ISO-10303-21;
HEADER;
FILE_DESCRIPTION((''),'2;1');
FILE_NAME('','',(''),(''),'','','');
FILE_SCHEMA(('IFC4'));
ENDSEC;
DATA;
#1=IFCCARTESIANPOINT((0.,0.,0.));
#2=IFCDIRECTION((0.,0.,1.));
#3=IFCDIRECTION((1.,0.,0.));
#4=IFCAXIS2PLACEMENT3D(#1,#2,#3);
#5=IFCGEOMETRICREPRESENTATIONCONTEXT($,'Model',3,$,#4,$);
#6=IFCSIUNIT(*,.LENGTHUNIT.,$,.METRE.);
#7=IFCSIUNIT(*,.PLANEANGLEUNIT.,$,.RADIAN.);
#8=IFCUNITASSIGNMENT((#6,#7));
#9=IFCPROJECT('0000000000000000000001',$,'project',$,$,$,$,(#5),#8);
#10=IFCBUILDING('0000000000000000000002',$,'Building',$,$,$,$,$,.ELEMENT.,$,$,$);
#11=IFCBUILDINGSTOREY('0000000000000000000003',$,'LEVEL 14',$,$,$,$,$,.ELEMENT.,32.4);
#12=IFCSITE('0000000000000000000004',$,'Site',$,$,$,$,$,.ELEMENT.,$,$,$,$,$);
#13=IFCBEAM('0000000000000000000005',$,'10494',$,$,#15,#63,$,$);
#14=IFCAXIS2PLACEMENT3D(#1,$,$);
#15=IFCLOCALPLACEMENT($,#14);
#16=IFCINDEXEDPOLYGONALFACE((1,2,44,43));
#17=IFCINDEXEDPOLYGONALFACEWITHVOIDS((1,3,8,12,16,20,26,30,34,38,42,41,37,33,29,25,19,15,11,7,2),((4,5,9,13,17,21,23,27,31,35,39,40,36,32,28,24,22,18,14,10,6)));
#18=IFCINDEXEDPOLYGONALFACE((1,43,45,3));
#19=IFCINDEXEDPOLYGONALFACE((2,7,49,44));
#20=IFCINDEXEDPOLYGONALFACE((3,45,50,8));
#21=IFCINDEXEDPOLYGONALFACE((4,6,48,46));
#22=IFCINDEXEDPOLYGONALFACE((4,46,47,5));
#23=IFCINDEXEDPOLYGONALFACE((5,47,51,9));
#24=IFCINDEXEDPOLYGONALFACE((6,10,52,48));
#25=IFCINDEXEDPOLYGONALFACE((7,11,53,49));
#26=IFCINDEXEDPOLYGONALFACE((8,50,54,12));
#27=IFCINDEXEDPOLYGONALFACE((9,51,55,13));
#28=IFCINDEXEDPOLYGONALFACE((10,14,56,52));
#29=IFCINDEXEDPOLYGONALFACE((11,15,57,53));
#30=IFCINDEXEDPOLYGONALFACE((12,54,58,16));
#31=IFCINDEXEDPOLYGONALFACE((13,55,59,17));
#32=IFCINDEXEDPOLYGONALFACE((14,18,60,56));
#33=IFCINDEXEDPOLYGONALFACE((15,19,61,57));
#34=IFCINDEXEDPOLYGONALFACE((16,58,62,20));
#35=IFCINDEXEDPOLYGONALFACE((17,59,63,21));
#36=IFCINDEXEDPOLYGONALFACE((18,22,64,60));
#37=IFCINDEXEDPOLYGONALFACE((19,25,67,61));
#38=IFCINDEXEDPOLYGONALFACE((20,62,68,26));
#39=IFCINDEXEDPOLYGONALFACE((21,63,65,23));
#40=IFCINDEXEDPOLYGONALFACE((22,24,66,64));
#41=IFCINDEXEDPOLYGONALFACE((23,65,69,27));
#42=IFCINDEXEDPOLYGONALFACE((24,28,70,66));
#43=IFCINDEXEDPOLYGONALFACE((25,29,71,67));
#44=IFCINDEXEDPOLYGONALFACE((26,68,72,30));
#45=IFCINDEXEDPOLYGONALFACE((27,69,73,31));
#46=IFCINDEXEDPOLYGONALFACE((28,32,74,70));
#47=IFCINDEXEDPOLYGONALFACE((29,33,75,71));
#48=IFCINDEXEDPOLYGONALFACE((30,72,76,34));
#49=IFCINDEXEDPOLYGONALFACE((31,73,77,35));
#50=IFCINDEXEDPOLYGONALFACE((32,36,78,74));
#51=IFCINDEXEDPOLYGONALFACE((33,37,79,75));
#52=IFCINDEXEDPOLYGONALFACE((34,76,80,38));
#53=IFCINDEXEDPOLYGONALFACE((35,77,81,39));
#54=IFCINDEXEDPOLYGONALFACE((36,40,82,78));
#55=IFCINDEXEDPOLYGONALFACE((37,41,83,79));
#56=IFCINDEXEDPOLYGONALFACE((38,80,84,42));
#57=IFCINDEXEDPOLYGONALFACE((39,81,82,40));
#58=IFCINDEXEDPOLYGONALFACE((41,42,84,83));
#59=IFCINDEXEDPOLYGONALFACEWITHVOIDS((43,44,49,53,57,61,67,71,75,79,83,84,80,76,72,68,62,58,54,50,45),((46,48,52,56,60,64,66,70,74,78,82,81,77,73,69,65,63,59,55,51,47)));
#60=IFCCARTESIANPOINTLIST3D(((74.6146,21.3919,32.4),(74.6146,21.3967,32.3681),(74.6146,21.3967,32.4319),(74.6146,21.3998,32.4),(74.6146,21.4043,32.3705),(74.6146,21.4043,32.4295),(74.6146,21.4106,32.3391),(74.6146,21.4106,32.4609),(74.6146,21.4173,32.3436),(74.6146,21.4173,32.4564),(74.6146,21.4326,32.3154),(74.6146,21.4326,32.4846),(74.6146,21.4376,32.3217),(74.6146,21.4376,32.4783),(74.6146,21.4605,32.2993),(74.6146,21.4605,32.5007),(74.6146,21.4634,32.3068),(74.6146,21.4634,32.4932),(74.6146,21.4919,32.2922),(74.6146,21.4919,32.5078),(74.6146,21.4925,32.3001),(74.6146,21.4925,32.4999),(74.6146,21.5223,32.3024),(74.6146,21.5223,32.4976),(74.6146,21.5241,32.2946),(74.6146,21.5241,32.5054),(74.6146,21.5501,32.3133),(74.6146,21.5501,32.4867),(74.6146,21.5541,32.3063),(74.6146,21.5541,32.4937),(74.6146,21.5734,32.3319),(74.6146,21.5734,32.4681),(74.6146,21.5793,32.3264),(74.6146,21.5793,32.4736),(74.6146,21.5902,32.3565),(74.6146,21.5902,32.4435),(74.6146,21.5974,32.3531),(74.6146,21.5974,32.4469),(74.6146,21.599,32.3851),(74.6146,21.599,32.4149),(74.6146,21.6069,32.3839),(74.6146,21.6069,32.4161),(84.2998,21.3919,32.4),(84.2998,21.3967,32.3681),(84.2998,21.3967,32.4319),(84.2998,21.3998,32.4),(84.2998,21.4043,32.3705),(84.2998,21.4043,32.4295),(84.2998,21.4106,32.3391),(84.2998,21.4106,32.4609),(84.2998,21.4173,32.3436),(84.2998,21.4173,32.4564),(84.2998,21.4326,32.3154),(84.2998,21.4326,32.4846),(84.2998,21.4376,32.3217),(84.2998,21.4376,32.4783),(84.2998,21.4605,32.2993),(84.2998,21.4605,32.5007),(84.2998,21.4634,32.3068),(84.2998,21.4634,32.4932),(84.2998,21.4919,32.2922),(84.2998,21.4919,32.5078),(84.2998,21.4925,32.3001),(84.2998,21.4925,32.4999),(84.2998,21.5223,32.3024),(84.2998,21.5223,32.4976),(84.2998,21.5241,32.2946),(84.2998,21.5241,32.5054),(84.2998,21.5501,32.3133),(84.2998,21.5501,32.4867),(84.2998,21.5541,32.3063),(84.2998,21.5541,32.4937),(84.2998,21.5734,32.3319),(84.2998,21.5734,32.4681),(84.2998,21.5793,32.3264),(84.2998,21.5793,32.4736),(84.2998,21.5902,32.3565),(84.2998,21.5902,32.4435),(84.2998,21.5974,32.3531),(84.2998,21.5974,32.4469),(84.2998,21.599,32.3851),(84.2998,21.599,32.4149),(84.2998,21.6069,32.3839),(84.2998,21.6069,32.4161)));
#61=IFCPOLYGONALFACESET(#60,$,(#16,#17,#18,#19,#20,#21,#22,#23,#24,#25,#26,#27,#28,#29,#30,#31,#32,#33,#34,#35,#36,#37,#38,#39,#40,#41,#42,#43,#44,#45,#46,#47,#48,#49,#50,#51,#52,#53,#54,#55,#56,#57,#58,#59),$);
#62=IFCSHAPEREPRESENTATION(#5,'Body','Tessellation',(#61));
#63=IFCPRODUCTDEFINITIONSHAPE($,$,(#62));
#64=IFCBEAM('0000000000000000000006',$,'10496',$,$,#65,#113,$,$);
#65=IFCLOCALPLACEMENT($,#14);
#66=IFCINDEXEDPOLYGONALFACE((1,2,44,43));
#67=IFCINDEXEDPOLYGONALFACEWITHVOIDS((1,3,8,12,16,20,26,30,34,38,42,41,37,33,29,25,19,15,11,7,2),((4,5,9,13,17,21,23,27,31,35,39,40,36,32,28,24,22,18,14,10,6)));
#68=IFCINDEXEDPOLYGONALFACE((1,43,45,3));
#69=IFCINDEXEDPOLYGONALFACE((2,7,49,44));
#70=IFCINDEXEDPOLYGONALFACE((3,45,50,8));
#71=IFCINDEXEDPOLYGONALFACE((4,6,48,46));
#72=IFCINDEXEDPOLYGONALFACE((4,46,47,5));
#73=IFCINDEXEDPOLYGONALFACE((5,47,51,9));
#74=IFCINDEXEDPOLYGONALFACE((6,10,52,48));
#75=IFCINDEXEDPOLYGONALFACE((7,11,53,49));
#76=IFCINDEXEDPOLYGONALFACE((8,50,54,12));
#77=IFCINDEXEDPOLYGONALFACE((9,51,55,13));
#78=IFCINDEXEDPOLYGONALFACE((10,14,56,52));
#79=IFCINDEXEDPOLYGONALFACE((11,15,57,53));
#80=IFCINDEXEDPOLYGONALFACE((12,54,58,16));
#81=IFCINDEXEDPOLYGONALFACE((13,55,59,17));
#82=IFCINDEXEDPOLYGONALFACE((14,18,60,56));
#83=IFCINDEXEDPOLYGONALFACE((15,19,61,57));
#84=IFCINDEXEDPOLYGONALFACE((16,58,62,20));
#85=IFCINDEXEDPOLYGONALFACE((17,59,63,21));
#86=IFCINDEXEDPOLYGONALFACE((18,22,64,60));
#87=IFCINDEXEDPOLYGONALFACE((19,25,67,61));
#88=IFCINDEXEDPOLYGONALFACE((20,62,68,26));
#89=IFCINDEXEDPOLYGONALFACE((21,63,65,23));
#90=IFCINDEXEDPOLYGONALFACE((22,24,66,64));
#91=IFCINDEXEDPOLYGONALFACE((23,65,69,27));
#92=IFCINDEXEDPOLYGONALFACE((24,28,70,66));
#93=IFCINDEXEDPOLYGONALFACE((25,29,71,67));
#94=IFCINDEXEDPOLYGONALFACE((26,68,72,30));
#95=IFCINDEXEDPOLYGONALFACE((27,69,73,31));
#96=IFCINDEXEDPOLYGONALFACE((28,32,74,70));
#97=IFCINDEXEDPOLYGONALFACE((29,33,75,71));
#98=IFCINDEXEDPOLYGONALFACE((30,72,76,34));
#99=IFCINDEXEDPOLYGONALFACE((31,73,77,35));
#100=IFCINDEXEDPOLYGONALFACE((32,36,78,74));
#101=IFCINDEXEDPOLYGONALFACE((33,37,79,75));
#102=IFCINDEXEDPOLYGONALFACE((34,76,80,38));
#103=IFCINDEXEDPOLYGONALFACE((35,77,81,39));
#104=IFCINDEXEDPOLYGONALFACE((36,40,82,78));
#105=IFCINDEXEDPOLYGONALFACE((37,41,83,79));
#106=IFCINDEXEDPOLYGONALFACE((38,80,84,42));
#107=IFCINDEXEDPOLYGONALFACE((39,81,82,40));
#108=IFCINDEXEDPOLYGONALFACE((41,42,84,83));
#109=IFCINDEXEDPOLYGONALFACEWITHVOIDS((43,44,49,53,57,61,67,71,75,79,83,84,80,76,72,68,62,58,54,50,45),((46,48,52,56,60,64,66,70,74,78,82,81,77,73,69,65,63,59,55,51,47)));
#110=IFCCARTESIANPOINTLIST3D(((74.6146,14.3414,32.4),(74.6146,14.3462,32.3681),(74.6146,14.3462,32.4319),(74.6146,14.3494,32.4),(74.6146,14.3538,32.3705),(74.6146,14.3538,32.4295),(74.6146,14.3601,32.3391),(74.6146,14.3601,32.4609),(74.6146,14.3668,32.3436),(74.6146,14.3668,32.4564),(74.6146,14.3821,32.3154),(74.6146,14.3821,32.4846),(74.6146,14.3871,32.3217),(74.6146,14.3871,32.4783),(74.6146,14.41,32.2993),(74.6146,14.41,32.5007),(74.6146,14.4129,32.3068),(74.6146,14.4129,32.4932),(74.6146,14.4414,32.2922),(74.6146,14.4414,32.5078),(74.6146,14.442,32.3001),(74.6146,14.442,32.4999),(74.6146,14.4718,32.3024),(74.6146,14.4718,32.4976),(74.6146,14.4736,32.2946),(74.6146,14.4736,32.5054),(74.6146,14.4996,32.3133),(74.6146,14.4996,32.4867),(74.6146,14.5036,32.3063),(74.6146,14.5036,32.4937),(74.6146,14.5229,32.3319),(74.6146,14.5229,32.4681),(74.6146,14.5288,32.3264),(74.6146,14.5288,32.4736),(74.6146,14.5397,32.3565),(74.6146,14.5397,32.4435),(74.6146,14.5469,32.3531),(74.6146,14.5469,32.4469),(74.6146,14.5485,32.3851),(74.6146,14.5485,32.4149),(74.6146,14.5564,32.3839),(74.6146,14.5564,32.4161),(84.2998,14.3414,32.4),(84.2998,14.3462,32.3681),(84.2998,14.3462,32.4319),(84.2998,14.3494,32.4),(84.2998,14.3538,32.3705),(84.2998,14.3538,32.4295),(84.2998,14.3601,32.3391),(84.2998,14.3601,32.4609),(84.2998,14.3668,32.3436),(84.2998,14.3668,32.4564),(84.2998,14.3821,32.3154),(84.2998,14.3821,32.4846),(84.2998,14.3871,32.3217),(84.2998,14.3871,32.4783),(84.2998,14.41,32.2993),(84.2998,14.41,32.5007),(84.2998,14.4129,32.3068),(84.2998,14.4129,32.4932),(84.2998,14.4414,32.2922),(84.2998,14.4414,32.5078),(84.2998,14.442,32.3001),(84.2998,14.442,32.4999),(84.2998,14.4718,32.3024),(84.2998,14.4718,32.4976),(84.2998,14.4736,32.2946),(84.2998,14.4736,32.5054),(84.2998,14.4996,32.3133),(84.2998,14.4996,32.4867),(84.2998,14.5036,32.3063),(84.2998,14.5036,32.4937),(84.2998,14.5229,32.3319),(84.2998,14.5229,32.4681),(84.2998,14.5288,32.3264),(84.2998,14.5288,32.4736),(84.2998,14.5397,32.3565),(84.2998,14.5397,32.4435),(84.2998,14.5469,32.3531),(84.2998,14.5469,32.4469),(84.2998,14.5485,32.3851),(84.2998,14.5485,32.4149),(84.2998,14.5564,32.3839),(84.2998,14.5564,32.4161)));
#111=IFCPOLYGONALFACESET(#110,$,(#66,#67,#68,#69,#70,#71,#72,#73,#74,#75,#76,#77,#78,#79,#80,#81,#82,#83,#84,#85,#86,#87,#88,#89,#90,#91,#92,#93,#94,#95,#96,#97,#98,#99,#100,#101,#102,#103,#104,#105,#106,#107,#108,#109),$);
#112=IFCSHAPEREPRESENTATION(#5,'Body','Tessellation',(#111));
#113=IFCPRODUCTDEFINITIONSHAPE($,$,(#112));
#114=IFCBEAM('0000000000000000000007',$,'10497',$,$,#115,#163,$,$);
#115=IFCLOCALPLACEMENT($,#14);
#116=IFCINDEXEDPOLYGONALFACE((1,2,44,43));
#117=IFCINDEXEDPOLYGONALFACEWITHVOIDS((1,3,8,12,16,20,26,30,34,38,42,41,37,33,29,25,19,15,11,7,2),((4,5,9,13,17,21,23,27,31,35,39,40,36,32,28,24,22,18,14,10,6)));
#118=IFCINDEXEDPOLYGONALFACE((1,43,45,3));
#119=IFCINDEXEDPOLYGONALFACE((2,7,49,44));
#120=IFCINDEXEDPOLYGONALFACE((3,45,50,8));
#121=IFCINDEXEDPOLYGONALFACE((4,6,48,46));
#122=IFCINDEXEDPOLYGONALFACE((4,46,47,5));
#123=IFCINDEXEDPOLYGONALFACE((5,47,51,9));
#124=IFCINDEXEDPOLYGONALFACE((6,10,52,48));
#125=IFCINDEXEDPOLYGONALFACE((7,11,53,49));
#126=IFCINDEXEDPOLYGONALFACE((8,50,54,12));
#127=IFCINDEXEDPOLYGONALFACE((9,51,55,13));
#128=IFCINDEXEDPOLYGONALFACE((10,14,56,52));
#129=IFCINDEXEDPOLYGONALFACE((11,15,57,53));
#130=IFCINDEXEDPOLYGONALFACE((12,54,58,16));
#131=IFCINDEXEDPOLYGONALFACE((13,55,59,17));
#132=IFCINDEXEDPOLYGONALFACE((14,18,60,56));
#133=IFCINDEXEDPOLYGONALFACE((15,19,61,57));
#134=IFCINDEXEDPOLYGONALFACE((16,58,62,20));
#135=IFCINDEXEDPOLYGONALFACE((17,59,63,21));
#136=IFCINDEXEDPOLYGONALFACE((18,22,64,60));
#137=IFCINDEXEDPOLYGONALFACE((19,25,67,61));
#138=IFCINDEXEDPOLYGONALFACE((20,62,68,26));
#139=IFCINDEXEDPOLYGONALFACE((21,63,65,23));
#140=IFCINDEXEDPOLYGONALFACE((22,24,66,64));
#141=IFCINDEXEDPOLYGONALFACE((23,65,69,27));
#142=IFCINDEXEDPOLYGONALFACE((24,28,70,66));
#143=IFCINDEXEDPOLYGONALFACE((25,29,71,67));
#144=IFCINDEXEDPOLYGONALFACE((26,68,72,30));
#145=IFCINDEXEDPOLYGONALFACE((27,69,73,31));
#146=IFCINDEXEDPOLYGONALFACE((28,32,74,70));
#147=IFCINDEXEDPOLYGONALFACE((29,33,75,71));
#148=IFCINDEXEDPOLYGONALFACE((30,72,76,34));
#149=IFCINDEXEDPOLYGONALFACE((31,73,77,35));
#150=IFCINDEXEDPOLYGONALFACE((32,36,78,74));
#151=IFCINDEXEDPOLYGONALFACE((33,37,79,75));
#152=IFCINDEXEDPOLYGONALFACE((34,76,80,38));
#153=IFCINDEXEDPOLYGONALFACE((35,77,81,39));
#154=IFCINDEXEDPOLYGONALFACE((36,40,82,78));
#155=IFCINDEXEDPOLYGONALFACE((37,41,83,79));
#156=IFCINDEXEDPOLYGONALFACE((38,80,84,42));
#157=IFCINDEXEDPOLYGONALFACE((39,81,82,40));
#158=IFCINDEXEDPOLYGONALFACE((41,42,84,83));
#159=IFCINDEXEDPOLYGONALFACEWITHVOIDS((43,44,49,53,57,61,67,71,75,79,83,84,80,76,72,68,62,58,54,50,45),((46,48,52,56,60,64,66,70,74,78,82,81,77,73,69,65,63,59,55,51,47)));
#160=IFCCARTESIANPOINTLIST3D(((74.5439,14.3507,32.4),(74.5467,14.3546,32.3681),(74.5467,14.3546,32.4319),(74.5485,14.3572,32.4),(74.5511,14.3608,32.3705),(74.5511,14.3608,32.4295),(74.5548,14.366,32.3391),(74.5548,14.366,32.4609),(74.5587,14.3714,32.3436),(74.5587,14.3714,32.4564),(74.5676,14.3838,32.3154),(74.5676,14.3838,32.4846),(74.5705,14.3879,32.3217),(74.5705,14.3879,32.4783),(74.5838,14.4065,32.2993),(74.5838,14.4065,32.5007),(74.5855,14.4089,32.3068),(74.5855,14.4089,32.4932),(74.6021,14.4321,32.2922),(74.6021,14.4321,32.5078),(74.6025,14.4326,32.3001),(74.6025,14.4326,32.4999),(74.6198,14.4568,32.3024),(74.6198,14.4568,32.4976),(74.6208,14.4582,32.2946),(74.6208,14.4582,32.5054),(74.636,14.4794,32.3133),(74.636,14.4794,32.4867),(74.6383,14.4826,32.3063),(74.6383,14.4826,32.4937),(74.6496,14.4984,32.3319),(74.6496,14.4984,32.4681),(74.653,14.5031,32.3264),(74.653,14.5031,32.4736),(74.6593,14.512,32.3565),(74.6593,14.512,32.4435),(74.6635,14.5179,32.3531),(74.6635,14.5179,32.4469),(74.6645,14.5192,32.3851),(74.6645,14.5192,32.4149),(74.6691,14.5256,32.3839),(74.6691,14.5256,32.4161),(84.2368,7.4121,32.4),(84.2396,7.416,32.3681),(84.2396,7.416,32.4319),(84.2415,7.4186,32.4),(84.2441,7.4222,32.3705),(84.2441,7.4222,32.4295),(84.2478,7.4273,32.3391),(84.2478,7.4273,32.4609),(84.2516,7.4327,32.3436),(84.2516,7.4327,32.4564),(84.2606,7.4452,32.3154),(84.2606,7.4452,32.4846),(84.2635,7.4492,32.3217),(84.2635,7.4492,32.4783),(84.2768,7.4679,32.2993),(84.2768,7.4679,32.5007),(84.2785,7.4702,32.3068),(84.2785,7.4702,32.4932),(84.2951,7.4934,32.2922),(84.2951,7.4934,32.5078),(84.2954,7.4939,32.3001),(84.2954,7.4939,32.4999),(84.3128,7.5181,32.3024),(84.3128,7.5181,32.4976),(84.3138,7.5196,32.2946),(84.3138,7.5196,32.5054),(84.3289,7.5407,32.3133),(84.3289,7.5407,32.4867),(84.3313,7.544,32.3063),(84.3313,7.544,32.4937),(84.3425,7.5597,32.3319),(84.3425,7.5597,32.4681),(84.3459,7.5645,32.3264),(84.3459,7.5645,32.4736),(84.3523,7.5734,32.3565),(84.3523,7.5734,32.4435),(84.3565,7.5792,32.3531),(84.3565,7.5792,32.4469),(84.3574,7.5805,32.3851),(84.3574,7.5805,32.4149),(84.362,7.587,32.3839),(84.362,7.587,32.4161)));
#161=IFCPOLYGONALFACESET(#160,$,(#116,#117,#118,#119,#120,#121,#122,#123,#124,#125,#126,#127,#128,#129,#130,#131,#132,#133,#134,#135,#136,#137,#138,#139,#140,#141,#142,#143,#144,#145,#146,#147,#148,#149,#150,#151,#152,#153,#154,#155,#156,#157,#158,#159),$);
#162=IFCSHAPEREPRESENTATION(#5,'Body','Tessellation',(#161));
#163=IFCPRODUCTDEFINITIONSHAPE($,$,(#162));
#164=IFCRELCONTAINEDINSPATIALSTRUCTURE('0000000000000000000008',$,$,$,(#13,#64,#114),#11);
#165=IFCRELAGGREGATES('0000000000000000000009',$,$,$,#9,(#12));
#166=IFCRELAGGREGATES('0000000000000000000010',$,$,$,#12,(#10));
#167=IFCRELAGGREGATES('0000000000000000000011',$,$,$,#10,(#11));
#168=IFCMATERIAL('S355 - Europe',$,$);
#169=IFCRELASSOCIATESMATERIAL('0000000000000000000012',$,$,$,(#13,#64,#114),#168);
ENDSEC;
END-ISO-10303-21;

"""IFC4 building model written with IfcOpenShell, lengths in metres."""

from ifc_helpers import new_model, si_unit, frame, origin_with_axes, origin_2d_with_axis, place, context, project, spatial, hollow_circle, extrude, material, material_profile, profile_set, profile_usage, element, save


model = new_model("IFC4")

# Units and contexts
model_context = context("Model", 3, world=origin_with_axes())
ifc_project = project(units=[si_unit("LENGTHUNIT", "METRE"), si_unit("PLANEANGLEUNIT", "RADIAN")], contexts=[model_context])

# Site, building, storey
site = spatial("IfcSite", under=ifc_project, Name="Site", CompositionType="ELEMENT")
building = spatial("IfcBuilding", under=site, Name="Building", CompositionType="ELEMENT")
storey = spatial("IfcBuildingStorey", under=building, Name="LEVEL 14", CompositionType="ELEMENT", Elevation=32.4)

# Shared definitions
ifc_material = material(Name="S355 - Europe")

# Beams
ifc_material_profile_1 = material_profile(ifc_material, hollow_circle(Radius=0.1081, WallThickness=0.008, at=origin_2d_with_axis()))
ifc_profile_set_1 = profile_set([ifc_material_profile_1])
ifc_profile_usage_1 = profile_usage(ifc_profile_set_1, cardinal=10)
beam_1_placement = place(None, frame((84.2998, 21.5, 32.4), z_axis=(-1.0, 0.0, 0.0), x_axis=(0.0, -1.0, 0.0)))
element("IfcBeam", 1, at=beam_1_placement, inside=storey, material=ifc_profile_usage_1, Name="10494", context=model_context, shape_type="SweptSolid", body=[
    extrude(hollow_circle(Radius=0.1081, WallThickness=0.008, at=origin_2d_with_axis()), origin_with_axes(), (0.0, 0.0, 1.0), 9.6852),
])
ifc_material_profile_2 = material_profile(ifc_material, hollow_circle(Radius=0.1081, WallThickness=0.008, at=origin_2d_with_axis()))
ifc_profile_set_2 = profile_set([ifc_material_profile_2])
ifc_profile_usage_2 = profile_usage(ifc_profile_set_2, cardinal=10)
beam_2_placement = place(None, frame((84.2998, 14.4495, 32.4), z_axis=(-1.0, 0.0, 0.0), x_axis=(0.0, -1.0, 0.0)))
element("IfcBeam", 2, at=beam_2_placement, inside=storey, material=ifc_profile_usage_2, Name="10496", context=model_context, shape_type="SweptSolid", body=[
    extrude(hollow_circle(Radius=0.1081, WallThickness=0.008, at=origin_2d_with_axis()), origin_with_axes(), (0.0, 0.0, 1.0), 9.6852),
])
ifc_material_profile_3 = material_profile(ifc_material, hollow_circle(Radius=0.1081, WallThickness=0.008, at=origin_2d_with_axis()))
ifc_profile_set_3 = profile_set([ifc_material_profile_3])
ifc_profile_usage_3 = profile_usage(ifc_profile_set_3, cardinal=10)
beam_3_placement = place(None, frame((84.2998, 7.5, 32.4), z_axis=(-0.813134, 0.582077, 0.0), x_axis=(-0.582987, -0.812482, 0.0)))
element("IfcBeam", 3, at=beam_3_placement, inside=storey, material=ifc_profile_usage_3, Name="10497", context=model_context, shape_type="SweptSolid", body=[
    extrude(hollow_circle(Radius=0.1081, WallThickness=0.008, at=origin_2d_with_axis()), origin_with_axes(), (0.0, 0.0, 1.0), 11.9205),
])

save(model, "model.ifc")
